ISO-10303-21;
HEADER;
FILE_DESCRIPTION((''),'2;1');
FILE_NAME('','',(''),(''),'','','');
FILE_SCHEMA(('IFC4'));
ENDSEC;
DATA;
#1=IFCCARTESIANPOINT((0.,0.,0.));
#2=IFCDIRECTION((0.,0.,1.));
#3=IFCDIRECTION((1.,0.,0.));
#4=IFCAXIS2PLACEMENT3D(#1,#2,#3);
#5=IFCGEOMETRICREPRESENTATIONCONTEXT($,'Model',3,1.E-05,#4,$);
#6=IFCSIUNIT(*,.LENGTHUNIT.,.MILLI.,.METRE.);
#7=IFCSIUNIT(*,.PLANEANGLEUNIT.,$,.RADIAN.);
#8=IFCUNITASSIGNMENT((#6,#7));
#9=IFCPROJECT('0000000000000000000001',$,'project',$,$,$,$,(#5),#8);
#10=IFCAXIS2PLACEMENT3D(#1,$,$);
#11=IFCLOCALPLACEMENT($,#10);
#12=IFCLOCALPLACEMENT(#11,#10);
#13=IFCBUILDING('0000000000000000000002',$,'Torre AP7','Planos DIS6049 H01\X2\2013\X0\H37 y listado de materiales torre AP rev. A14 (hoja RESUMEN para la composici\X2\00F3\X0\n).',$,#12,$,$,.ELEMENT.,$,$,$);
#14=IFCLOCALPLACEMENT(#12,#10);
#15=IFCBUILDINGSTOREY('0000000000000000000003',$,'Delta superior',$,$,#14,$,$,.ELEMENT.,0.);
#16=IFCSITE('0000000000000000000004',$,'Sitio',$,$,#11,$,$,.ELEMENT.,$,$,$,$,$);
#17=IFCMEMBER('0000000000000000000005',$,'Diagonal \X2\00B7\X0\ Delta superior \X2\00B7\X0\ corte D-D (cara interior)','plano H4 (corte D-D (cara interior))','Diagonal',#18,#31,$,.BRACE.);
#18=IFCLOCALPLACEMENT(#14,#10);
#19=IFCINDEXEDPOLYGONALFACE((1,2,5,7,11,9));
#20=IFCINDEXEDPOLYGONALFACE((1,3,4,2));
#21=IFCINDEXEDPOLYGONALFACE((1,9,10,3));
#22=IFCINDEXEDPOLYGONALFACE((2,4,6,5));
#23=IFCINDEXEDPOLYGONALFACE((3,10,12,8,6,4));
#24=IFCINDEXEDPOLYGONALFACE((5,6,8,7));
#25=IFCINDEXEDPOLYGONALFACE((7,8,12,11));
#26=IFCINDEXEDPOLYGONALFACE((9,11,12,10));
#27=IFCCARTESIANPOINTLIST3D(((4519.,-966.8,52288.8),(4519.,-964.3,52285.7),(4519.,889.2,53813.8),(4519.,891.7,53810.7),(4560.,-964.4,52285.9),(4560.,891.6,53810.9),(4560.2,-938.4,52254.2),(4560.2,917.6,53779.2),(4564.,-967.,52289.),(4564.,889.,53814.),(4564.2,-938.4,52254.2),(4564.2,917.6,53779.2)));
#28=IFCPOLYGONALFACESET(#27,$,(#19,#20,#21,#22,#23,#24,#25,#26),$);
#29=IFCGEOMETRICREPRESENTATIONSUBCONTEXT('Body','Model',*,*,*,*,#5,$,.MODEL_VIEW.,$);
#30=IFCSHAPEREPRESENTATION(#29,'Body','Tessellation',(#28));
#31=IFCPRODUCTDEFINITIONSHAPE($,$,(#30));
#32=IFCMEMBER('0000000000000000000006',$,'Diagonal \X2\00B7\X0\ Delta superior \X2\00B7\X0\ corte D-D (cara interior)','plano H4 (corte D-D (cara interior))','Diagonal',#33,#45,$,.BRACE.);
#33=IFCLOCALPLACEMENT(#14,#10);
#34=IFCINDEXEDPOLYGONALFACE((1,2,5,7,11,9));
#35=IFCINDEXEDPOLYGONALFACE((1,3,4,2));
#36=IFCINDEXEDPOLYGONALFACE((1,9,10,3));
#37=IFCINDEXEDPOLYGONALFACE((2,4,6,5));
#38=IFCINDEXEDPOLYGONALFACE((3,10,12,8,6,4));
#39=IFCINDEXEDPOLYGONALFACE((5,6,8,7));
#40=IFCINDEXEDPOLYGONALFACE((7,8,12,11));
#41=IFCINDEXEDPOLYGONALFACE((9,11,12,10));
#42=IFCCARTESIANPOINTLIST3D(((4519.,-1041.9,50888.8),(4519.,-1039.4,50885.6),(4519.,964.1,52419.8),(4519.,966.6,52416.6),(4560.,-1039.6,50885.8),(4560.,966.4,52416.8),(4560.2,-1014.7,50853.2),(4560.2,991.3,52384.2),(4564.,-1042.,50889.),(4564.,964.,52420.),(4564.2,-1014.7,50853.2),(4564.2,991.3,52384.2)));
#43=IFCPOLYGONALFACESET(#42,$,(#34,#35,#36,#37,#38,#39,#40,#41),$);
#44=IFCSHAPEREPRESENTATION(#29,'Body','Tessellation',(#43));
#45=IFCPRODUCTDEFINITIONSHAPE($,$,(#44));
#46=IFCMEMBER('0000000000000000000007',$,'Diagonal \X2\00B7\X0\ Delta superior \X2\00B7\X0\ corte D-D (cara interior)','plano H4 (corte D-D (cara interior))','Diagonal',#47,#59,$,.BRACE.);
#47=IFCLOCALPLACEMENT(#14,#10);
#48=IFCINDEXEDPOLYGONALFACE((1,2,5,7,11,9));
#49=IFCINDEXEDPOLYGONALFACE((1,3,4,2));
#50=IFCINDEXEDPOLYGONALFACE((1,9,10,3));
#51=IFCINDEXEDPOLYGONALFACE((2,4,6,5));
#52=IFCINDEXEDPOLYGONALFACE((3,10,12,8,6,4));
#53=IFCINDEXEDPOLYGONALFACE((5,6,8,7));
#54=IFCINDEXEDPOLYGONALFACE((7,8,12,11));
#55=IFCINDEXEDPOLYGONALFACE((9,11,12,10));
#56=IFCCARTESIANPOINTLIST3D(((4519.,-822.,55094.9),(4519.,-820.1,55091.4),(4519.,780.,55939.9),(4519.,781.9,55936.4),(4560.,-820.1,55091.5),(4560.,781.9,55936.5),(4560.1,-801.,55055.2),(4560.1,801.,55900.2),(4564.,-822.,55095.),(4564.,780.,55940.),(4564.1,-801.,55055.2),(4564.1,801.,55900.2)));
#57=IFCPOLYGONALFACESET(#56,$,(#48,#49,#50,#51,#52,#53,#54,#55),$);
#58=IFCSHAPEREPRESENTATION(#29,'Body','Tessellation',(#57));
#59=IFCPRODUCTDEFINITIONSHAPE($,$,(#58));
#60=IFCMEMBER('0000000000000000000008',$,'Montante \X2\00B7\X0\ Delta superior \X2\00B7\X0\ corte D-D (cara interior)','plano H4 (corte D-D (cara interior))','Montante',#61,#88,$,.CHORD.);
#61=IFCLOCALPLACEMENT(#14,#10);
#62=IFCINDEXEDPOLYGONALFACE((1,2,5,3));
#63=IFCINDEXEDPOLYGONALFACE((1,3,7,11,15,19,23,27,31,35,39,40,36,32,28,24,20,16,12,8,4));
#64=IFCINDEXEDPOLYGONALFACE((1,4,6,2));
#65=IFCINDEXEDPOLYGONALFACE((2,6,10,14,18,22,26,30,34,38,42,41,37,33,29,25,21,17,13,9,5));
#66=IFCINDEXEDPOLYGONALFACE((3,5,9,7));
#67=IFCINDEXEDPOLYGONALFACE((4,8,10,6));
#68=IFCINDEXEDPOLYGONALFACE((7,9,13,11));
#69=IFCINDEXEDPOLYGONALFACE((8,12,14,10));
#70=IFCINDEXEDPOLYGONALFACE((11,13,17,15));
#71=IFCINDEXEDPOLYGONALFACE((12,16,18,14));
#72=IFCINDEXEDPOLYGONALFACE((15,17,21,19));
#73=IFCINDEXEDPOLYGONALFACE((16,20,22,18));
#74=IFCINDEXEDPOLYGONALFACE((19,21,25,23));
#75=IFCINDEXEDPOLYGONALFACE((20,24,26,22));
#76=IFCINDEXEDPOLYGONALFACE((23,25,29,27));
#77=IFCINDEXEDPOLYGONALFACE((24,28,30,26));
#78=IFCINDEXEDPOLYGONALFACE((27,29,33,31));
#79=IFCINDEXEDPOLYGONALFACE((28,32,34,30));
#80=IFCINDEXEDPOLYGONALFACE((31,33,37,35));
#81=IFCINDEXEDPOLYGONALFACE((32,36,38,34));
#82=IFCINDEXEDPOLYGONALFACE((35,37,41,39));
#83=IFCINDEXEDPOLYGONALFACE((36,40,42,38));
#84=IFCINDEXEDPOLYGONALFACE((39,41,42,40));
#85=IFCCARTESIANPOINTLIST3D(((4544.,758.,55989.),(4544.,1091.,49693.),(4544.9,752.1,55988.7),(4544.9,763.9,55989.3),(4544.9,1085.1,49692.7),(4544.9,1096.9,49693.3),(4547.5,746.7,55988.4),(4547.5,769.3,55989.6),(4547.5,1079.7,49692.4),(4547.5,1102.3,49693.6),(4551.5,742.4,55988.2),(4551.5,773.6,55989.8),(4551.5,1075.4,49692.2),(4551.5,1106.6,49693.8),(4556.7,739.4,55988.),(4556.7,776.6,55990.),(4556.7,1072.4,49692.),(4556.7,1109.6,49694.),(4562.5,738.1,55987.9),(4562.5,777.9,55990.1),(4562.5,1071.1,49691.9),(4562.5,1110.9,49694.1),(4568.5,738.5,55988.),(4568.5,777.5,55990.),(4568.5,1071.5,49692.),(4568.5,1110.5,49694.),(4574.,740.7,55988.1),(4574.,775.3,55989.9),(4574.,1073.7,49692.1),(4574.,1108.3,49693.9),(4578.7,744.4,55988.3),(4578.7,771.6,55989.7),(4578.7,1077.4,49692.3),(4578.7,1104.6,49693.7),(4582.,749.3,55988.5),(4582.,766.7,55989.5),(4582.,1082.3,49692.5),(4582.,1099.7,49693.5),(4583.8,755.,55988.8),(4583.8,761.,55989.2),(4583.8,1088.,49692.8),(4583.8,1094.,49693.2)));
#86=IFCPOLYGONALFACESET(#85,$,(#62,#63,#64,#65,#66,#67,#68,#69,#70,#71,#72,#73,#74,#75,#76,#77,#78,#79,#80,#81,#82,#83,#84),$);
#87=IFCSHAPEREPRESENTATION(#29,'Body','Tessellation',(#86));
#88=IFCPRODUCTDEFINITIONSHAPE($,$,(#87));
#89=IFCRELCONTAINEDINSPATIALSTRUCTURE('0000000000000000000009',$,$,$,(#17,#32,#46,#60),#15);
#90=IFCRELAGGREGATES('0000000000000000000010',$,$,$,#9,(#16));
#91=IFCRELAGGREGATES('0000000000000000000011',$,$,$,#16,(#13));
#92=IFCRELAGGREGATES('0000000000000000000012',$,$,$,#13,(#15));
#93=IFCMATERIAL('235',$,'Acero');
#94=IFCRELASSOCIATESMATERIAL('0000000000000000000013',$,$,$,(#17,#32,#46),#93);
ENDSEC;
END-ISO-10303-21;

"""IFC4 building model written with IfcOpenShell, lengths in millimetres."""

from ifc_helpers import new_model, si_unit, frame, frame_2d, origin, origin_with_axes, place, context, subcontext, project, spatial, circle, l_section, extrude, material, element, save


model = new_model("IFC4")

# Units and contexts
model_context = context("Model", 3, precision=1e-05, world=origin_with_axes())
body_context = subcontext(model_context, "Body", "Model", "MODEL_VIEW")
ifc_project = project(units=[si_unit("LENGTHUNIT", "METRE", prefix="MILLI"), si_unit("PLANEANGLEUNIT", "RADIAN")], contexts=[model_context])

# Site, building, storey
site_placement = place(None, origin())
site = spatial("IfcSite", under=ifc_project, at=site_placement, Name="Sitio", CompositionType="ELEMENT")
building_placement = place(site_placement, origin())
building = spatial("IfcBuilding", under=site, at=building_placement, Name="Torre AP7", Description="Planos DIS6049 H01–H37 y listado de materiales torre AP rev. A14 (hoja RESUMEN para la composición).", CompositionType="ELEMENT")
storey_placement = place(building_placement, origin())
storey = spatial("IfcBuildingStorey", under=building, at=storey_placement, Name="Delta superior", CompositionType="ELEMENT", Elevation=0.0)

# Members
ifc_material_1 = material(Name="235", Category="Acero")
member_1_placement = place(storey_placement, frame((4564.0, 889.0, 53814.0), z_axis=(0.0, -0.772639, -0.634846), x_axis=(-0.999985, 0.003444, -0.004191)))
element("IfcMember", 1, at=member_1_placement, inside=storey, material=ifc_material_1, Name="Diagonal · Delta superior · corte D-D (cara interior)", Description="plano H4 (corte D-D (cara interior))", ObjectType="Diagonal", PredefinedType="BRACE", context=body_context, shape_type="SweptSolid", body=[
    extrude(l_section(Depth=45.0, Width=45.0, Thickness=4.0, at=frame_2d((22.5, 22.5))), None, (0.0, 0.0, 1.0), 2402.2),
])
member_2_placement = place(storey_placement, frame((4564.0, 964.0, 52420.0), z_axis=(0.0, -0.794931, -0.6067), x_axis=(-0.999987, 0.003145, -0.004121)))
element("IfcMember", 2, at=member_2_placement, inside=storey, material=ifc_material_1, Name="Diagonal · Delta superior · corte D-D (cara interior)", Description="plano H4 (corte D-D (cara interior))", ObjectType="Diagonal", PredefinedType="BRACE", context=body_context, shape_type="SweptSolid", body=[
    extrude(l_section(Depth=45.0, Width=45.0, Thickness=4.0, at=frame_2d((22.5, 22.5))), None, (0.0, 0.0, 1.0), 2523.5),
])
member_3_placement = place(storey_placement, frame((4564.0, 780.0, 55940.0), z_axis=(0.0, -0.884499, -0.466543), x_axis=(-0.999998, 0.001002, -0.001899)))
element("IfcMember", 3, at=member_3_placement, inside=storey, material=ifc_material_1, Name="Diagonal · Delta superior · corte D-D (cara interior)", Description="plano H4 (corte D-D (cara interior))", ObjectType="Diagonal", PredefinedType="BRACE", context=body_context, shape_type="SweptSolid", body=[
    extrude(l_section(Depth=45.0, Width=45.0, Thickness=4.0, at=frame_2d((22.5, 22.5))), None, (0.0, 0.0, 1.0), 1811.2),
])
member_4_placement = place(storey_placement, frame((4564.0, 1091.0, 49693.0), z_axis=(0.0, -0.052817, 0.998604), x_axis=(-1.0, 0.0, 0.0)))
element("IfcMember", 4, at=member_4_placement, inside=storey, Name="Montante · Delta superior · corte D-D (cara interior)", Description="plano H4 (corte D-D (cara interior))", ObjectType="Montante", PredefinedType="CHORD", context=body_context, shape_type="SweptSolid", body=[
    extrude(circle(Radius=20.0), None, (0.0, 0.0, 1.0), 6304.8),
])

save(model, "model.ifc")
